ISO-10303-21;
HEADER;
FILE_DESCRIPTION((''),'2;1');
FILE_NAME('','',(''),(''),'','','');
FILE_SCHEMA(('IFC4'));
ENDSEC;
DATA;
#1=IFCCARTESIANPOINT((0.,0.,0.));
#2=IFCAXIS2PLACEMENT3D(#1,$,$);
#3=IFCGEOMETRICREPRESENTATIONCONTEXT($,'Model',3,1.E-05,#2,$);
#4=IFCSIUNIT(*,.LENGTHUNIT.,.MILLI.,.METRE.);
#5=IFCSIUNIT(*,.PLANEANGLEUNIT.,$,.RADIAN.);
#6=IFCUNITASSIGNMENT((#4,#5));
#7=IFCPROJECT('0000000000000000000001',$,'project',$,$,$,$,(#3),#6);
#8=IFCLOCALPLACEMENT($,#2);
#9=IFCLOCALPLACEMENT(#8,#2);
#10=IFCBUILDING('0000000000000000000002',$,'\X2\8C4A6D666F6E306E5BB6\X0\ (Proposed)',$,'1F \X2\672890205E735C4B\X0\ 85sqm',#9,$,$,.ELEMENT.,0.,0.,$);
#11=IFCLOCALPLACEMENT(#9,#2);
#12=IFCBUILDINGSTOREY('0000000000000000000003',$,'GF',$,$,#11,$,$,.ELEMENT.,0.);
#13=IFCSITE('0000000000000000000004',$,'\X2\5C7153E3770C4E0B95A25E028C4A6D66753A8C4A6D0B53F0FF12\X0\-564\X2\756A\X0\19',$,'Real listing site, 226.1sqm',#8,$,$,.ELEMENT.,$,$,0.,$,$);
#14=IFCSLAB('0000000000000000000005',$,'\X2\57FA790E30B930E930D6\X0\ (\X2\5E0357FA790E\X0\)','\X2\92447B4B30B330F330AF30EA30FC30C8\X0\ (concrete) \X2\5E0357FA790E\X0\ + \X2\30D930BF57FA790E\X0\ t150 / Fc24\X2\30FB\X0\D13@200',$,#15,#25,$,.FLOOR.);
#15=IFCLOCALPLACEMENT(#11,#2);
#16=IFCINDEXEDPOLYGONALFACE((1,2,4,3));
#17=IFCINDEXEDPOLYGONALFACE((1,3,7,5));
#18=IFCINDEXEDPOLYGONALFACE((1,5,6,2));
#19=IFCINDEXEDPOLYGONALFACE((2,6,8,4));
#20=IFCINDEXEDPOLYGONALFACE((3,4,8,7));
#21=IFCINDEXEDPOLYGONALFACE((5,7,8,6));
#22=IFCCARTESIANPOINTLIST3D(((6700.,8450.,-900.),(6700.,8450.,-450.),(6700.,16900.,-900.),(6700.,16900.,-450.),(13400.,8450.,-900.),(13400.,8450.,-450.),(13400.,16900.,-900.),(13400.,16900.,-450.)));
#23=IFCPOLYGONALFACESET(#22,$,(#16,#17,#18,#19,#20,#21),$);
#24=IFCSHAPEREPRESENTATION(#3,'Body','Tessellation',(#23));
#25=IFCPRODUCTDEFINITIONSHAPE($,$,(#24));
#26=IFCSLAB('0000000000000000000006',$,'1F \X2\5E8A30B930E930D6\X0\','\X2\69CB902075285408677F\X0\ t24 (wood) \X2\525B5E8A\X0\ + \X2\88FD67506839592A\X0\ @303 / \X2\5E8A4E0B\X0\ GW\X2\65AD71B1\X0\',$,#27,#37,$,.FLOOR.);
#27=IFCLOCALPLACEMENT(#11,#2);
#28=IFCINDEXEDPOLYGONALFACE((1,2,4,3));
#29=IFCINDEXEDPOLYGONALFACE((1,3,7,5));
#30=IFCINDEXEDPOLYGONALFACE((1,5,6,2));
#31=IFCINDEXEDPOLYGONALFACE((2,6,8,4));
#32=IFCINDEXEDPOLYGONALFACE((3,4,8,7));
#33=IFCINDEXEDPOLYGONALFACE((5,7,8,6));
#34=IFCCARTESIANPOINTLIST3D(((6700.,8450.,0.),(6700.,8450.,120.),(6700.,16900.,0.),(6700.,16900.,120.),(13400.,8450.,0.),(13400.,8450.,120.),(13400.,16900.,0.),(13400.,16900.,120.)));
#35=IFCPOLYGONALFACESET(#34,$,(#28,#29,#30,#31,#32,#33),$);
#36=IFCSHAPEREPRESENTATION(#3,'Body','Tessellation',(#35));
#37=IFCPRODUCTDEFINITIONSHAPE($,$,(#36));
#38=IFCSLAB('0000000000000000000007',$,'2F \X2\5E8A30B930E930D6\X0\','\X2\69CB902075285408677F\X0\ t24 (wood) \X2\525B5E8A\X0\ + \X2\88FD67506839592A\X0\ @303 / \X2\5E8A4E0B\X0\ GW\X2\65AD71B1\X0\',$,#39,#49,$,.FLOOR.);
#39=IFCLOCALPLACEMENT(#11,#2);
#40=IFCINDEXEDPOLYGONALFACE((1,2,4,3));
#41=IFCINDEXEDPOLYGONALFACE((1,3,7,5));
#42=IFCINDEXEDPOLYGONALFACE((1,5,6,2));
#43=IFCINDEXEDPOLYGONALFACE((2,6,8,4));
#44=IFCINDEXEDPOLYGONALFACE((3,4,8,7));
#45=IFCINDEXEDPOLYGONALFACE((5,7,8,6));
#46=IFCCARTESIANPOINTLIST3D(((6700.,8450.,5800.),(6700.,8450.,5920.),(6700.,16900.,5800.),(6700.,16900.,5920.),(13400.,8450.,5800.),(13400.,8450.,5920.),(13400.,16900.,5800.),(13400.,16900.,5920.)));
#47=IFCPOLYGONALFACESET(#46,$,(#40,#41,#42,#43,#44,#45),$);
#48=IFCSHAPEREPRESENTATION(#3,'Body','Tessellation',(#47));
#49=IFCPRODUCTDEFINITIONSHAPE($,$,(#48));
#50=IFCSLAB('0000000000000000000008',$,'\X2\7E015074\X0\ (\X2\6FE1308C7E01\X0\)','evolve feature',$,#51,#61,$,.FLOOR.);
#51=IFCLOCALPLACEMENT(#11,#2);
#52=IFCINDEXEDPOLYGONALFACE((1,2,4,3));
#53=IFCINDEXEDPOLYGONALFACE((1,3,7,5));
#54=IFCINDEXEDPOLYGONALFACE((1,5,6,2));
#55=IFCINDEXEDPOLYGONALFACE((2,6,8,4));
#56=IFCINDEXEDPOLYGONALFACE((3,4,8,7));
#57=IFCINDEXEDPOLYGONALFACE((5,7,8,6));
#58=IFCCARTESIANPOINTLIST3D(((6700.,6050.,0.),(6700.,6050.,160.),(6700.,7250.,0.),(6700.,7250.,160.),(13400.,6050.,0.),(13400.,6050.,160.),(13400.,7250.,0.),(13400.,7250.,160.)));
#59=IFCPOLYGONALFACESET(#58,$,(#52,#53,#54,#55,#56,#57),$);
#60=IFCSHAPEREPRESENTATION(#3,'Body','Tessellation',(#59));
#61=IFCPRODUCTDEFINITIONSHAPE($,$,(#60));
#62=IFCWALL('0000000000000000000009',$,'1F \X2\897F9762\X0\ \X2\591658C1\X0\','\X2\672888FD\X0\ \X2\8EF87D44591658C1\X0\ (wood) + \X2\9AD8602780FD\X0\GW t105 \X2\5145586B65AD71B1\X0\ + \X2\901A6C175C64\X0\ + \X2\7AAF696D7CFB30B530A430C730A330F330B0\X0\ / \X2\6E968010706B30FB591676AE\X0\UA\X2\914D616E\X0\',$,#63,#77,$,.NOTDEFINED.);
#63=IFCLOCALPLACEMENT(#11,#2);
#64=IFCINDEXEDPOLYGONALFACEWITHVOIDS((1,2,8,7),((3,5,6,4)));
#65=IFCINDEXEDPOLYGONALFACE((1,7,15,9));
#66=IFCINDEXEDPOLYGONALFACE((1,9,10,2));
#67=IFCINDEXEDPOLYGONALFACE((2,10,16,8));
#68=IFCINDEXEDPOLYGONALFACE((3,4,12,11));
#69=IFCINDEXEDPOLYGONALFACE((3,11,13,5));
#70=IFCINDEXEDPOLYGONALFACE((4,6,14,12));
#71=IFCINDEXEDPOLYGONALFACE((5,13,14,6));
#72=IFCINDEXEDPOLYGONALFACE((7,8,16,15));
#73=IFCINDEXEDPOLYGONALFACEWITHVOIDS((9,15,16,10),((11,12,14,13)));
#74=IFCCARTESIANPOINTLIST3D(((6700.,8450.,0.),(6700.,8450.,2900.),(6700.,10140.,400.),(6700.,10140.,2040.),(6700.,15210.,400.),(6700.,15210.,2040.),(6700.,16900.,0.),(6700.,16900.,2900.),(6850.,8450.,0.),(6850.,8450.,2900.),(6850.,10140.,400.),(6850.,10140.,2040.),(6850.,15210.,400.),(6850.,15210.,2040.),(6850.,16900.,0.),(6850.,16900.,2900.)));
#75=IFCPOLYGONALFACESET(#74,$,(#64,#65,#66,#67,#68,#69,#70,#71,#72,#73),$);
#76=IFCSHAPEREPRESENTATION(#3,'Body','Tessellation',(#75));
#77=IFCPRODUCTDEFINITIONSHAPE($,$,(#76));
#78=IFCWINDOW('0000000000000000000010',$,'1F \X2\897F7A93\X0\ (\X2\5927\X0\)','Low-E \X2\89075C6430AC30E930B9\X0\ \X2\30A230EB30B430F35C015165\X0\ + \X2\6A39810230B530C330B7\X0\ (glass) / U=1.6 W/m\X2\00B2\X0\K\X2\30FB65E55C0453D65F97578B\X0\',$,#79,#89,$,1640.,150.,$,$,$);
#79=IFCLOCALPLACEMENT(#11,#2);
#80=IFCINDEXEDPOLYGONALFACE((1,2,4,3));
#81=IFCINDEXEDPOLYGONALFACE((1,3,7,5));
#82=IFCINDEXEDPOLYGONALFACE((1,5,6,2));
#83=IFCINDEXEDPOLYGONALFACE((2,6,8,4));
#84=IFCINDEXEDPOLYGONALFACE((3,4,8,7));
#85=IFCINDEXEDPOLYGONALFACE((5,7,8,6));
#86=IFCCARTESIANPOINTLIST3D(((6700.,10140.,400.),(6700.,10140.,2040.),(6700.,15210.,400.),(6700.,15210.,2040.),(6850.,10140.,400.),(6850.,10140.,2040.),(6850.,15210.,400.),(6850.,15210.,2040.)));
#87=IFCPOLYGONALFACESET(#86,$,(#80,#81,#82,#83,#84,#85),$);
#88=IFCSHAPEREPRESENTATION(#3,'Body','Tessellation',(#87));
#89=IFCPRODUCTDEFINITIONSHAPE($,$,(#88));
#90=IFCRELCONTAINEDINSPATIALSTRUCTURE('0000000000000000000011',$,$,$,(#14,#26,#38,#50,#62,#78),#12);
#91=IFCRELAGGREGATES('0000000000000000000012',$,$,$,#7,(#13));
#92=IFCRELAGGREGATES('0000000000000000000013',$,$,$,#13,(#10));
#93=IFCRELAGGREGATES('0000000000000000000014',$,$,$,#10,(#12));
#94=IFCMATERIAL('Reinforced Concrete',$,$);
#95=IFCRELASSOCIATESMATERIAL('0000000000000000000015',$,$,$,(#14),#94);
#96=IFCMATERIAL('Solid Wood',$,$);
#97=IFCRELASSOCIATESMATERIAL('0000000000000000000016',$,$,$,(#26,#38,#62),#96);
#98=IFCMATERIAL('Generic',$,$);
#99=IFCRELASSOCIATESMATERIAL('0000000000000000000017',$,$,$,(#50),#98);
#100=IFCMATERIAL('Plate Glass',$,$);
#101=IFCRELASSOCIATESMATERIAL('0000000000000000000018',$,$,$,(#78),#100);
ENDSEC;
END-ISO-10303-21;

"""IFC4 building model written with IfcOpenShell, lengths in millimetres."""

from ifc_helpers import new_model, si_unit, frame, frame_2d, origin, place, context, project, spatial, rectangle, extrude, material, element, fill, save


model = new_model("IFC4")

# Units and contexts
model_context = context("Model", 3, precision=1e-05, world=origin())
ifc_project = project(units=[si_unit("LENGTHUNIT", "METRE", prefix="MILLI"), si_unit("PLANEANGLEUNIT", "RADIAN")], contexts=[model_context])

# Site, building, storey
site_placement = place(None, origin())
site = spatial("IfcSite", under=ifc_project, at=site_placement, Name="山口県下関市豊浦町豊洋台２-564番19", ObjectType="Real listing site, 226.1sqm", CompositionType="ELEMENT", RefElevation=0.0)
building_placement = place(site_placement, origin())
building = spatial("IfcBuilding", under=site, at=building_placement, Name="豊浦潮の家 (Proposed)", ObjectType="1F 木造平屋 85sqm", CompositionType="ELEMENT", ElevationOfRefHeight=0.0, ElevationOfTerrain=0.0)
storey_placement = place(building_placement, origin())
storey = spatial("IfcBuildingStorey", under=building, at=storey_placement, Name="GF", CompositionType="ELEMENT", Elevation=0.0)

# Slabs
ifc_material_1 = material(Name="Reinforced Concrete")
slab_1_placement = place(storey_placement, frame((3350.0, 4225.0, -450.0)))
element("IfcSlab", 1, at=slab_1_placement, inside=storey, material=ifc_material_1, Name="基礎スラブ (布基礎)", Description="鉄筋コンクリート (concrete) 布基礎 + ベタ基礎 t150 / Fc24・D13@200", PredefinedType="FLOOR", context=model_context, shape_type="SweptSolid", body=[
    extrude(rectangle(XDim=6700.0, YDim=8450.0, at=frame_2d((3350.0, 4225.0))), frame((3350.0, 4225.0, -450.0)), (0.0, 0.0, 1.0), 450.0),
])
ifc_material_2 = material(Name="Solid Wood")
slab_2_placement = place(storey_placement, frame((3350.0, 4225.0, 0.0)))
element("IfcSlab", 2, at=slab_2_placement, inside=storey, material=ifc_material_2, Name="1F 床スラブ", Description="構造用合板 t24 (wood) 剛床 + 製材根太 @303 / 床下 GW断熱", PredefinedType="FLOOR", context=model_context, shape_type="SweptSolid", body=[
    extrude(rectangle(XDim=6700.0, YDim=8450.0, at=frame_2d((3350.0, 4225.0))), frame((3350.0, 4225.0, 0.0)), (0.0, 0.0, 1.0), 120.0),
])
slab_3_placement = place(storey_placement, frame((3350.0, 4225.0, 2900.0)))
element("IfcSlab", 3, at=slab_3_placement, inside=storey, material=ifc_material_2, Name="2F 床スラブ", Description="構造用合板 t24 (wood) 剛床 + 製材根太 @303 / 床下 GW断熱", PredefinedType="FLOOR", context=model_context, shape_type="SweptSolid", body=[
    extrude(rectangle(XDim=6700.0, YDim=8450.0, at=frame_2d((3350.0, 4225.0))), frame((3350.0, 4225.0, 2900.0)), (0.0, 0.0, 1.0), 120.0),
])
ifc_material_3 = material(Name="Generic")
slab_4_placement = place(storey_placement, frame((3350.0, 3025.0, 0.0)))
element("IfcSlab", 4, at=slab_4_placement, inside=storey, material=ifc_material_3, Name="縁側 (濡れ縁)", Description="evolve feature", PredefinedType="FLOOR", context=model_context, shape_type="SweptSolid", body=[
    extrude(rectangle(XDim=6700.0, YDim=1200.0, at=frame_2d((3350.0, 600.0))), frame((3350.0, 3025.0, 0.0)), (0.0, 0.0, 1.0), 160.0),
])

# Shared definitions
ifc_material_4 = material(Name="Plate Glass")

# Wall, opening, window
wall_1_placement = place(storey_placement, frame((3350.0, 4225.0, 0.0)))
wall_1 = element("IfcWall", 5, at=wall_1_placement, inside=storey, material=ifc_material_2, Name="1F 西面 外壁", Description="木製 軸組外壁 (wood) + 高性能GW t105 充填断熱 + 通気層 + 窯業系サイディング / 準耐火・外皮UA配慮", PredefinedType="NOTDEFINED", context=model_context, shape_type="SweptSolid", body=[
    extrude(rectangle(XDim=150.0, YDim=8450.0, at=frame_2d((75.0, 4225.0))), frame((3350.0, 4225.0, 0.0)), (0.0, 0.0, 1.0), 2900.0),
])
opening_1_placement = place(storey_placement, frame((3350.0, 5070.0, 200.0)))
opening_1 = element("IfcOpeningElement", 6, at=opening_1_placement, cuts=wall_1, PredefinedType="NOTDEFINED", context=model_context, shape_type="SweptSolid", body=[
    extrude(rectangle(XDim=150.0, YDim=5070.0, at=frame_2d((75.0, 2535.0))), frame((3350.0, 5070.0, 200.0)), (0.0, 0.0, 1.0), 1640.0),
])
window_1_placement = place(storey_placement, frame((3350.0, 5070.0, 200.0)))
window_1 = element("IfcWindow", 7, at=window_1_placement, inside=storey, material=ifc_material_4, Name="1F 西窓 (大)", Description="Low-E 複層ガラス アルゴン封入 + 樹脂サッシ (glass) / U=1.6 W/m²K・日射取得型", OverallHeight=1640.0, OverallWidth=150.0, context=model_context, shape_type="SweptSolid", body=[
    extrude(rectangle(XDim=150.0, YDim=5070.0, at=frame_2d((75.0, 2535.0))), frame((3350.0, 5070.0, 200.0)), (0.0, 0.0, 1.0), 1640.0),
])
fill(opening_1, window_1)

save(model, "model.ifc")
